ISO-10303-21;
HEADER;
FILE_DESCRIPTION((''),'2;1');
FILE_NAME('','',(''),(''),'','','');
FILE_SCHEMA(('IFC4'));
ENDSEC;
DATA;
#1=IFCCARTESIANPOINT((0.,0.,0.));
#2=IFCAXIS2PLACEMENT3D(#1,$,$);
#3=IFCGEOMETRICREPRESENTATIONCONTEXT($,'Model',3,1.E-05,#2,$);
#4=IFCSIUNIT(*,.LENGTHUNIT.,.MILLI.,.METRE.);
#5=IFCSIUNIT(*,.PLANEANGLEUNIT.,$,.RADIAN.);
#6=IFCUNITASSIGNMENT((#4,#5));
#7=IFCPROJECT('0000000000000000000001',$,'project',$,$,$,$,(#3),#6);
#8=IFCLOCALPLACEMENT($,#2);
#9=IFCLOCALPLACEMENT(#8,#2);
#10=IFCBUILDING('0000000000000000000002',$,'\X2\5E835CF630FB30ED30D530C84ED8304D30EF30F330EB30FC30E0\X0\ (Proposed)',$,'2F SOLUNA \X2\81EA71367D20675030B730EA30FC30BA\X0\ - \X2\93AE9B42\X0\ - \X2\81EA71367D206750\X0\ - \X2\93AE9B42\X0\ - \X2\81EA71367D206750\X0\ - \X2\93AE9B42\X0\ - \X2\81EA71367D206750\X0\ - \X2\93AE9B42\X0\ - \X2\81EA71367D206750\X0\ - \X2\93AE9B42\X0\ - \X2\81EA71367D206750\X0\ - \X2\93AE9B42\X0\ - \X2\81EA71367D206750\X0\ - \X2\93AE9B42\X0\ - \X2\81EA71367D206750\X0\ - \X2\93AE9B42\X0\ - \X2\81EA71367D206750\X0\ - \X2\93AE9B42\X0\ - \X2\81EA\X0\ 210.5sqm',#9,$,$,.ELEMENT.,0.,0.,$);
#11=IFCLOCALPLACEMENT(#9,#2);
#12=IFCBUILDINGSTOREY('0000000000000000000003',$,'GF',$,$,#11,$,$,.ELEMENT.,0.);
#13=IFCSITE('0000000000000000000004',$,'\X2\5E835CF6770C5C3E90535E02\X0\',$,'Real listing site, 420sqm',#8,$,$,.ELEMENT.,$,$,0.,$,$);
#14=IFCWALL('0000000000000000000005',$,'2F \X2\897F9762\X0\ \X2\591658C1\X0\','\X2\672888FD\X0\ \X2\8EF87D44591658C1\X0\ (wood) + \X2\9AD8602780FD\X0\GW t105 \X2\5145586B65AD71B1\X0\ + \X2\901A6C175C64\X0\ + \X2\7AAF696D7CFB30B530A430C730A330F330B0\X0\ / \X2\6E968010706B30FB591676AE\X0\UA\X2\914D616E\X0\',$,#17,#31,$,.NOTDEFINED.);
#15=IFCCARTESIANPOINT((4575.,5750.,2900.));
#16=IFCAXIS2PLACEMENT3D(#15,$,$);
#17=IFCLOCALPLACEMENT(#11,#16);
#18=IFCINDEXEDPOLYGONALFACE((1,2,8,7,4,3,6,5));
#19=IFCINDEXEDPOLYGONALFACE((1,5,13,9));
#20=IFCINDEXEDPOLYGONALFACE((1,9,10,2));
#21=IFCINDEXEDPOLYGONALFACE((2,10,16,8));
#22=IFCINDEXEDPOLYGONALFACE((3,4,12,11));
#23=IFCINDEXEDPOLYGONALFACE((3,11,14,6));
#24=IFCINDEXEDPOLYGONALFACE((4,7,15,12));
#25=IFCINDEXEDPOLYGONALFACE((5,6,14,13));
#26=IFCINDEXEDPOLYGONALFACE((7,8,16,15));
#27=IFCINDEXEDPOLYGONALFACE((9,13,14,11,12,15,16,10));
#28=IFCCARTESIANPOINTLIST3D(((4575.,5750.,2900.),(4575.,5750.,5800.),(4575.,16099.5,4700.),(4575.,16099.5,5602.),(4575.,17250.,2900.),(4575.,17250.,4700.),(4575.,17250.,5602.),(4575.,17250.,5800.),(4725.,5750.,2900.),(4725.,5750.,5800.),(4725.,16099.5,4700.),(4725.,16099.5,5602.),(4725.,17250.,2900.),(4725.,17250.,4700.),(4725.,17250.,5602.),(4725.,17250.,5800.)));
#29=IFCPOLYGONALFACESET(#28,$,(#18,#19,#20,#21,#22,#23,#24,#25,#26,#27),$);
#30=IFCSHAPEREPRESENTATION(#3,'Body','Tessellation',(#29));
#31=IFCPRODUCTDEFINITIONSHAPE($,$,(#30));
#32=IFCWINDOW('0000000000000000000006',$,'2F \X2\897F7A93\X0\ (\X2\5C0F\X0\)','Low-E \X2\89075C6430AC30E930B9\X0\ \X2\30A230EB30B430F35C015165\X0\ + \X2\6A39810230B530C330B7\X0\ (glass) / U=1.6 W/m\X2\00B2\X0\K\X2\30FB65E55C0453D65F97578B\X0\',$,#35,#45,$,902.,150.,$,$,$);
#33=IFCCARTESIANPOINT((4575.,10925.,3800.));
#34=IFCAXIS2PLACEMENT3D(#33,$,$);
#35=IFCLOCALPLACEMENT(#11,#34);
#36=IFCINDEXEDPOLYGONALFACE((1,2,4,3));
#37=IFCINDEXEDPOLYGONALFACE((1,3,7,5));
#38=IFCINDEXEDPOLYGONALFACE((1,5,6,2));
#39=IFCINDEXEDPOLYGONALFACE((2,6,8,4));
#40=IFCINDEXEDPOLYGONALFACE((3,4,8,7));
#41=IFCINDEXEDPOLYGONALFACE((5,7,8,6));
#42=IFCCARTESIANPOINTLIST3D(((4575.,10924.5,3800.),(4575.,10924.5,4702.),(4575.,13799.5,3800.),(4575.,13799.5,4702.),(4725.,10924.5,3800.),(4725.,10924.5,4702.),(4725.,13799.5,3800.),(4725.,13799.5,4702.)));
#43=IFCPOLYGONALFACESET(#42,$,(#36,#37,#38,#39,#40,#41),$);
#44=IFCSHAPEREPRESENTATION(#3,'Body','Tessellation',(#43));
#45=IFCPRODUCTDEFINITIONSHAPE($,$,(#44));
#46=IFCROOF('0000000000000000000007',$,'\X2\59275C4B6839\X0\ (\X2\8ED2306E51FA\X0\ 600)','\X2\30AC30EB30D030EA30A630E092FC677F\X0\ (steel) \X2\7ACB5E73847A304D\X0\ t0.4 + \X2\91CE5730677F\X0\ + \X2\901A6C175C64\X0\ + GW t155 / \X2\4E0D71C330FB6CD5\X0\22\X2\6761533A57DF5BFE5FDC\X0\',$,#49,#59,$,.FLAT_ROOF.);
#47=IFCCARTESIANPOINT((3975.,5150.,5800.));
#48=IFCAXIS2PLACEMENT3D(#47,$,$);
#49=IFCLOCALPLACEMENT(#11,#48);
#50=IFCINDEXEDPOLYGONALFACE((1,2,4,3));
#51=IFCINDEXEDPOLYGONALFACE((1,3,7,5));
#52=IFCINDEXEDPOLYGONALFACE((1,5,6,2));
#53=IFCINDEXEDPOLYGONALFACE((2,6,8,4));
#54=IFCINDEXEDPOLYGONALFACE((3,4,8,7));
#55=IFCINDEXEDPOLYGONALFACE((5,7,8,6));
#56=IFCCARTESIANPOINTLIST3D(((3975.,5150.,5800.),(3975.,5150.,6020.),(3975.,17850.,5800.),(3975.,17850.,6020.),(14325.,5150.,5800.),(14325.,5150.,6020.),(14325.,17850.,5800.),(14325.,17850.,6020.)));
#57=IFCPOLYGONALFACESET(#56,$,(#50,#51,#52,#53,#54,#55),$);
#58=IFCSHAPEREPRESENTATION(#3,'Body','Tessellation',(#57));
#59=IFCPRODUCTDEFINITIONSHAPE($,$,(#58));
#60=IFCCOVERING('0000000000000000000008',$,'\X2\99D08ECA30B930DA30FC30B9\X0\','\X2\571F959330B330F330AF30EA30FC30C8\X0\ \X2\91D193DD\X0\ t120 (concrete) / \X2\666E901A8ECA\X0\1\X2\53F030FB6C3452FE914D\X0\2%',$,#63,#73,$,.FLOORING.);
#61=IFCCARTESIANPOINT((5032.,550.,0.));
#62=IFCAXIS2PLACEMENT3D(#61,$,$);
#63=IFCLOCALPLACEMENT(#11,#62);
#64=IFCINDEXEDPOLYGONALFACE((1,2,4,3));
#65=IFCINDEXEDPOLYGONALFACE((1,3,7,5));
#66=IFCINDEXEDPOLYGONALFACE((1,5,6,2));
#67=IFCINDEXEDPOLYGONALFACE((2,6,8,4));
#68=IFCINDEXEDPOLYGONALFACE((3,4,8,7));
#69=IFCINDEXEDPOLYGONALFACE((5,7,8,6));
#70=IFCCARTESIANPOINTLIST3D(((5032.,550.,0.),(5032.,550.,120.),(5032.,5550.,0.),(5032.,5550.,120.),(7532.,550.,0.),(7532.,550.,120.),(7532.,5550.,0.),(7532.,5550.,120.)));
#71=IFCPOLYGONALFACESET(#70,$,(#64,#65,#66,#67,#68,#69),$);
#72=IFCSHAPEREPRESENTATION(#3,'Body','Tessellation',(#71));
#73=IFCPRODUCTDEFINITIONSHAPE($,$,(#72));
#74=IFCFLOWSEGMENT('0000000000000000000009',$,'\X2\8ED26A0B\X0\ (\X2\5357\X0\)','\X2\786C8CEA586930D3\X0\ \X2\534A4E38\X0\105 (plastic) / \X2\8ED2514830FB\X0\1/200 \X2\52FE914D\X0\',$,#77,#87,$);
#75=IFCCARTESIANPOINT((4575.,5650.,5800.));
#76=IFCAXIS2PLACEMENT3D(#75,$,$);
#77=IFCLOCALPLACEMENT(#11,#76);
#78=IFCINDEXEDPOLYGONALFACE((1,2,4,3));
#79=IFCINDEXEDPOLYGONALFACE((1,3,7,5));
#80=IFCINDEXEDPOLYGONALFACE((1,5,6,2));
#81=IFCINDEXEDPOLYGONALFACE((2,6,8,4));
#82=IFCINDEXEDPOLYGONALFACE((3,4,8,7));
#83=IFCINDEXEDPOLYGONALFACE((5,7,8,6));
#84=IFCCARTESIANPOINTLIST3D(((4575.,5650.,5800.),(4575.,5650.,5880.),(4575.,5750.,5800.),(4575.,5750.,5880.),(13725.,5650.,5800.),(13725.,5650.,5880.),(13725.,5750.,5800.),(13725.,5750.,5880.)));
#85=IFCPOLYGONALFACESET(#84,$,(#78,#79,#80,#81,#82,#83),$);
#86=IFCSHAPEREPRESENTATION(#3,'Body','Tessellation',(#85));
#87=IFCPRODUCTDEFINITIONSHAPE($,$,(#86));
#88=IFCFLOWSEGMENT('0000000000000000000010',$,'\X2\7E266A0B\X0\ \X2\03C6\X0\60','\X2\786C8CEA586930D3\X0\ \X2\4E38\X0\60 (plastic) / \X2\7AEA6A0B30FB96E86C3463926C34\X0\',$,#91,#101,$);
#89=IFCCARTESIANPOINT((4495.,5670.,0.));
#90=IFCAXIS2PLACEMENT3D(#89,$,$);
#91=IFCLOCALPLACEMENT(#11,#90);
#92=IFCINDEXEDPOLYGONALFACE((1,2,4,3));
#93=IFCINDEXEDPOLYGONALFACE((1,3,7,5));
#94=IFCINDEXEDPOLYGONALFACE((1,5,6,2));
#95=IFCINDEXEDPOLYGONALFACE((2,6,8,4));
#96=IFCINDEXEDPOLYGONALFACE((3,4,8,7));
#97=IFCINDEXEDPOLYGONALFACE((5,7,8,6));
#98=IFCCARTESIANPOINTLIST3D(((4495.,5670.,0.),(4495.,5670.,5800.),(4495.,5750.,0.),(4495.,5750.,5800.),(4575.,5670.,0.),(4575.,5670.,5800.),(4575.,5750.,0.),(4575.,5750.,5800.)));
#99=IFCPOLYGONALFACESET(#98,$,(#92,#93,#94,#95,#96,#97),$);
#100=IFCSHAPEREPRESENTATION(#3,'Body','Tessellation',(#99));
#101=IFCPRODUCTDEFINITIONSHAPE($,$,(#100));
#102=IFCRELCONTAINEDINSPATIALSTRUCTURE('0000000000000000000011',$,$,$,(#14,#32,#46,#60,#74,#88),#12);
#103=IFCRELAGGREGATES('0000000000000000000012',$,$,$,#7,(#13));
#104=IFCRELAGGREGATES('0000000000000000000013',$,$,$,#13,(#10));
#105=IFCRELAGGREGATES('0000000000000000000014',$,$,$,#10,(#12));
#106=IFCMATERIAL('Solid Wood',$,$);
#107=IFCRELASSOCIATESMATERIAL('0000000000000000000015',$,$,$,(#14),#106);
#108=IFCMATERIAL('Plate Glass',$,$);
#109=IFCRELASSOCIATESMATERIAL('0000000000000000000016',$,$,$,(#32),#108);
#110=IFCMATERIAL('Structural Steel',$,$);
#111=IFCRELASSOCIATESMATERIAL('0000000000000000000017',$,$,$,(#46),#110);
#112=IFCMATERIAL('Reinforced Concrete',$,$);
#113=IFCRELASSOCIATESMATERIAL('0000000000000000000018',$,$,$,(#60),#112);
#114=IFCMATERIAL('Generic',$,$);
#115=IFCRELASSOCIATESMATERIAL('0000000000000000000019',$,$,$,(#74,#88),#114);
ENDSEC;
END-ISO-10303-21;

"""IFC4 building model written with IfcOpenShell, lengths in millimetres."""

from ifc_helpers import new_model, si_unit, frame, frame_2d, origin, place, context, project, spatial, rectangle, extrude, material, element, fill, save


model = new_model("IFC4")

# Units and contexts
model_context = context("Model", 3, precision=1e-05, world=origin())
ifc_project = project(units=[si_unit("LENGTHUNIT", "METRE", prefix="MILLI"), si_unit("PLANEANGLEUNIT", "RADIAN")], contexts=[model_context])

# Site, building, storey
site_placement = place(None, origin())
site = spatial("IfcSite", under=ifc_project, at=site_placement, Name="広島県尾道市", ObjectType="Real listing site, 420sqm", CompositionType="ELEMENT", RefElevation=0.0)
building_placement = place(site_placement, origin())
building = spatial("IfcBuilding", under=site, at=building_placement, Name="広島・ロフト付きワンルーム (Proposed)", ObjectType="2F SOLUNA 自然素材シリーズ - 鎮魂 - 自然素材 - 鎮魂 - 自然素材 - 鎮魂 - 自然素材 - 鎮魂 - 自然素材 - 鎮魂 - 自然素材 - 鎮魂 - 自然素材 - 鎮魂 - 自然素材 - 鎮魂 - 自然素材 - 鎮魂 - 自 210.5sqm", CompositionType="ELEMENT", ElevationOfRefHeight=0.0, ElevationOfTerrain=0.0)
storey_placement = place(building_placement, origin())
storey = spatial("IfcBuildingStorey", under=building, at=storey_placement, Name="GF", CompositionType="ELEMENT", Elevation=0.0)

# Shared definitions
ifc_material_1 = material(Name="Solid Wood")

# Shared definitions
ifc_material_2 = material(Name="Reinforced Concrete")

# Shared definitions
ifc_material_3 = material(Name="Plate Glass")

# Wall, opening, window
wall_1_placement = place(storey_placement, frame((4575.0, 5750.0, 2900.0)))
wall_1 = element("IfcWall", 1, at=wall_1_placement, inside=storey, material=ifc_material_1, Name="2F 西面 外壁", Description="木製 軸組外壁 (wood) + 高性能GW t105 充填断熱 + 通気層 + 窯業系サイディング / 準耐火・外皮UA配慮", PredefinedType="NOTDEFINED", context=model_context, shape_type="SweptSolid", body=[
    extrude(rectangle(XDim=150.0, YDim=11500.0, at=frame_2d((75.0, 5750.0))), frame((4575.0, 5750.0, 2900.0)), (0.0, 0.0, 1.0), 2900.0),
])
opening_1_placement = place(storey_placement, frame((4575.0, 10925.0, 3800.0)))
opening_1 = element("IfcOpeningElement", 2, at=opening_1_placement, cuts=wall_1, PredefinedType="NOTDEFINED", context=model_context, shape_type="SweptSolid", body=[
    extrude(rectangle(XDim=150.0, YDim=2875.0, at=frame_2d((75.0, 1437.0))), frame((4575.0, 10925.0, 3800.0)), (0.0, 0.0, 1.0), 902.0),
])
window_1_placement = place(storey_placement, frame((4575.0, 10925.0, 3800.0)))
window_1 = element("IfcWindow", 3, at=window_1_placement, inside=storey, material=ifc_material_3, Name="2F 西窓 (小)", Description="Low-E 複層ガラス アルゴン封入 + 樹脂サッシ (glass) / U=1.6 W/m²K・日射取得型", OverallHeight=902.0, OverallWidth=150.0, context=model_context, shape_type="SweptSolid", body=[
    extrude(rectangle(XDim=150.0, YDim=2875.0, at=frame_2d((75.0, 1437.0))), frame((4575.0, 10925.0, 3800.0)), (0.0, 0.0, 1.0), 902.0),
])
fill(opening_1, window_1)

# Roof
ifc_material_4 = material(Name="Structural Steel")
roof_placement = place(storey_placement, frame((3975.0, 5150.0, 5800.0)))
element("IfcRoof", 4, at=roof_placement, inside=storey, material=ifc_material_4, Name="大屋根 (軒の出 600)", Description="ガルバリウム鋼板 (steel) 立平葺き t0.4 + 野地板 + 通気層 + GW t155 / 不燃・法22条区域対応", PredefinedType="FLAT_ROOF", context=model_context, shape_type="SweptSolid", body=[
    extrude(rectangle(XDim=10350.0, YDim=12700.0, at=frame_2d((5175.0, 6350.0))), frame((3975.0, 5150.0, 5800.0)), (0.0, 0.0, 1.0), 220.0),
])

# Covering
covering_placement = place(storey_placement, frame((5032.0, 550.0, 0.0)))
element("IfcCovering", 5, at=covering_placement, inside=storey, material=ifc_material_2, Name="駐車スペース", Description="土間コンクリート 金鏝 t120 (concrete) / 普通車1台・水勾配2%", PredefinedType="FLOORING", context=model_context, shape_type="SweptSolid", body=[
    extrude(rectangle(XDim=2500.0, YDim=5000.0, at=frame_2d((1250.0, 2500.0))), frame((5032.0, 550.0, 0.0)), (0.0, 0.0, 1.0), 120.0),
])

# Flow segments
ifc_material_5 = material(Name="Generic")
flow_segment_1_placement = place(storey_placement, frame((4575.0, 5650.0, 5800.0)))
element("IfcFlowSegment", 6, at=flow_segment_1_placement, inside=storey, material=ifc_material_5, Name="軒樋 (南)", Description="硬質塩ビ 半丸105 (plastic) / 軒先・1/200 勾配", context=model_context, shape_type="SweptSolid", body=[
    extrude(rectangle(XDim=9150.0, YDim=100.0, at=frame_2d((4575.0, 50.0))), frame((4575.0, 5650.0, 5800.0)), (0.0, 0.0, 1.0), 80.0),
])
flow_segment_2_placement = place(storey_placement, frame((4495.0, 5670.0, 0.0)))
element("IfcFlowSegment", 7, at=flow_segment_2_placement, inside=storey, material=ifc_material_5, Name="縦樋 φ60", Description="硬質塩ビ 丸60 (plastic) / 竪樋・雨水排水", context=model_context, shape_type="SweptSolid", body=[
    extrude(rectangle(XDim=80.0, YDim=80.0, at=frame_2d((40.0, 40.0))), frame((4495.0, 5670.0, 0.0)), (0.0, 0.0, 1.0), 5800.0),
])

save(model, "model.ifc")
